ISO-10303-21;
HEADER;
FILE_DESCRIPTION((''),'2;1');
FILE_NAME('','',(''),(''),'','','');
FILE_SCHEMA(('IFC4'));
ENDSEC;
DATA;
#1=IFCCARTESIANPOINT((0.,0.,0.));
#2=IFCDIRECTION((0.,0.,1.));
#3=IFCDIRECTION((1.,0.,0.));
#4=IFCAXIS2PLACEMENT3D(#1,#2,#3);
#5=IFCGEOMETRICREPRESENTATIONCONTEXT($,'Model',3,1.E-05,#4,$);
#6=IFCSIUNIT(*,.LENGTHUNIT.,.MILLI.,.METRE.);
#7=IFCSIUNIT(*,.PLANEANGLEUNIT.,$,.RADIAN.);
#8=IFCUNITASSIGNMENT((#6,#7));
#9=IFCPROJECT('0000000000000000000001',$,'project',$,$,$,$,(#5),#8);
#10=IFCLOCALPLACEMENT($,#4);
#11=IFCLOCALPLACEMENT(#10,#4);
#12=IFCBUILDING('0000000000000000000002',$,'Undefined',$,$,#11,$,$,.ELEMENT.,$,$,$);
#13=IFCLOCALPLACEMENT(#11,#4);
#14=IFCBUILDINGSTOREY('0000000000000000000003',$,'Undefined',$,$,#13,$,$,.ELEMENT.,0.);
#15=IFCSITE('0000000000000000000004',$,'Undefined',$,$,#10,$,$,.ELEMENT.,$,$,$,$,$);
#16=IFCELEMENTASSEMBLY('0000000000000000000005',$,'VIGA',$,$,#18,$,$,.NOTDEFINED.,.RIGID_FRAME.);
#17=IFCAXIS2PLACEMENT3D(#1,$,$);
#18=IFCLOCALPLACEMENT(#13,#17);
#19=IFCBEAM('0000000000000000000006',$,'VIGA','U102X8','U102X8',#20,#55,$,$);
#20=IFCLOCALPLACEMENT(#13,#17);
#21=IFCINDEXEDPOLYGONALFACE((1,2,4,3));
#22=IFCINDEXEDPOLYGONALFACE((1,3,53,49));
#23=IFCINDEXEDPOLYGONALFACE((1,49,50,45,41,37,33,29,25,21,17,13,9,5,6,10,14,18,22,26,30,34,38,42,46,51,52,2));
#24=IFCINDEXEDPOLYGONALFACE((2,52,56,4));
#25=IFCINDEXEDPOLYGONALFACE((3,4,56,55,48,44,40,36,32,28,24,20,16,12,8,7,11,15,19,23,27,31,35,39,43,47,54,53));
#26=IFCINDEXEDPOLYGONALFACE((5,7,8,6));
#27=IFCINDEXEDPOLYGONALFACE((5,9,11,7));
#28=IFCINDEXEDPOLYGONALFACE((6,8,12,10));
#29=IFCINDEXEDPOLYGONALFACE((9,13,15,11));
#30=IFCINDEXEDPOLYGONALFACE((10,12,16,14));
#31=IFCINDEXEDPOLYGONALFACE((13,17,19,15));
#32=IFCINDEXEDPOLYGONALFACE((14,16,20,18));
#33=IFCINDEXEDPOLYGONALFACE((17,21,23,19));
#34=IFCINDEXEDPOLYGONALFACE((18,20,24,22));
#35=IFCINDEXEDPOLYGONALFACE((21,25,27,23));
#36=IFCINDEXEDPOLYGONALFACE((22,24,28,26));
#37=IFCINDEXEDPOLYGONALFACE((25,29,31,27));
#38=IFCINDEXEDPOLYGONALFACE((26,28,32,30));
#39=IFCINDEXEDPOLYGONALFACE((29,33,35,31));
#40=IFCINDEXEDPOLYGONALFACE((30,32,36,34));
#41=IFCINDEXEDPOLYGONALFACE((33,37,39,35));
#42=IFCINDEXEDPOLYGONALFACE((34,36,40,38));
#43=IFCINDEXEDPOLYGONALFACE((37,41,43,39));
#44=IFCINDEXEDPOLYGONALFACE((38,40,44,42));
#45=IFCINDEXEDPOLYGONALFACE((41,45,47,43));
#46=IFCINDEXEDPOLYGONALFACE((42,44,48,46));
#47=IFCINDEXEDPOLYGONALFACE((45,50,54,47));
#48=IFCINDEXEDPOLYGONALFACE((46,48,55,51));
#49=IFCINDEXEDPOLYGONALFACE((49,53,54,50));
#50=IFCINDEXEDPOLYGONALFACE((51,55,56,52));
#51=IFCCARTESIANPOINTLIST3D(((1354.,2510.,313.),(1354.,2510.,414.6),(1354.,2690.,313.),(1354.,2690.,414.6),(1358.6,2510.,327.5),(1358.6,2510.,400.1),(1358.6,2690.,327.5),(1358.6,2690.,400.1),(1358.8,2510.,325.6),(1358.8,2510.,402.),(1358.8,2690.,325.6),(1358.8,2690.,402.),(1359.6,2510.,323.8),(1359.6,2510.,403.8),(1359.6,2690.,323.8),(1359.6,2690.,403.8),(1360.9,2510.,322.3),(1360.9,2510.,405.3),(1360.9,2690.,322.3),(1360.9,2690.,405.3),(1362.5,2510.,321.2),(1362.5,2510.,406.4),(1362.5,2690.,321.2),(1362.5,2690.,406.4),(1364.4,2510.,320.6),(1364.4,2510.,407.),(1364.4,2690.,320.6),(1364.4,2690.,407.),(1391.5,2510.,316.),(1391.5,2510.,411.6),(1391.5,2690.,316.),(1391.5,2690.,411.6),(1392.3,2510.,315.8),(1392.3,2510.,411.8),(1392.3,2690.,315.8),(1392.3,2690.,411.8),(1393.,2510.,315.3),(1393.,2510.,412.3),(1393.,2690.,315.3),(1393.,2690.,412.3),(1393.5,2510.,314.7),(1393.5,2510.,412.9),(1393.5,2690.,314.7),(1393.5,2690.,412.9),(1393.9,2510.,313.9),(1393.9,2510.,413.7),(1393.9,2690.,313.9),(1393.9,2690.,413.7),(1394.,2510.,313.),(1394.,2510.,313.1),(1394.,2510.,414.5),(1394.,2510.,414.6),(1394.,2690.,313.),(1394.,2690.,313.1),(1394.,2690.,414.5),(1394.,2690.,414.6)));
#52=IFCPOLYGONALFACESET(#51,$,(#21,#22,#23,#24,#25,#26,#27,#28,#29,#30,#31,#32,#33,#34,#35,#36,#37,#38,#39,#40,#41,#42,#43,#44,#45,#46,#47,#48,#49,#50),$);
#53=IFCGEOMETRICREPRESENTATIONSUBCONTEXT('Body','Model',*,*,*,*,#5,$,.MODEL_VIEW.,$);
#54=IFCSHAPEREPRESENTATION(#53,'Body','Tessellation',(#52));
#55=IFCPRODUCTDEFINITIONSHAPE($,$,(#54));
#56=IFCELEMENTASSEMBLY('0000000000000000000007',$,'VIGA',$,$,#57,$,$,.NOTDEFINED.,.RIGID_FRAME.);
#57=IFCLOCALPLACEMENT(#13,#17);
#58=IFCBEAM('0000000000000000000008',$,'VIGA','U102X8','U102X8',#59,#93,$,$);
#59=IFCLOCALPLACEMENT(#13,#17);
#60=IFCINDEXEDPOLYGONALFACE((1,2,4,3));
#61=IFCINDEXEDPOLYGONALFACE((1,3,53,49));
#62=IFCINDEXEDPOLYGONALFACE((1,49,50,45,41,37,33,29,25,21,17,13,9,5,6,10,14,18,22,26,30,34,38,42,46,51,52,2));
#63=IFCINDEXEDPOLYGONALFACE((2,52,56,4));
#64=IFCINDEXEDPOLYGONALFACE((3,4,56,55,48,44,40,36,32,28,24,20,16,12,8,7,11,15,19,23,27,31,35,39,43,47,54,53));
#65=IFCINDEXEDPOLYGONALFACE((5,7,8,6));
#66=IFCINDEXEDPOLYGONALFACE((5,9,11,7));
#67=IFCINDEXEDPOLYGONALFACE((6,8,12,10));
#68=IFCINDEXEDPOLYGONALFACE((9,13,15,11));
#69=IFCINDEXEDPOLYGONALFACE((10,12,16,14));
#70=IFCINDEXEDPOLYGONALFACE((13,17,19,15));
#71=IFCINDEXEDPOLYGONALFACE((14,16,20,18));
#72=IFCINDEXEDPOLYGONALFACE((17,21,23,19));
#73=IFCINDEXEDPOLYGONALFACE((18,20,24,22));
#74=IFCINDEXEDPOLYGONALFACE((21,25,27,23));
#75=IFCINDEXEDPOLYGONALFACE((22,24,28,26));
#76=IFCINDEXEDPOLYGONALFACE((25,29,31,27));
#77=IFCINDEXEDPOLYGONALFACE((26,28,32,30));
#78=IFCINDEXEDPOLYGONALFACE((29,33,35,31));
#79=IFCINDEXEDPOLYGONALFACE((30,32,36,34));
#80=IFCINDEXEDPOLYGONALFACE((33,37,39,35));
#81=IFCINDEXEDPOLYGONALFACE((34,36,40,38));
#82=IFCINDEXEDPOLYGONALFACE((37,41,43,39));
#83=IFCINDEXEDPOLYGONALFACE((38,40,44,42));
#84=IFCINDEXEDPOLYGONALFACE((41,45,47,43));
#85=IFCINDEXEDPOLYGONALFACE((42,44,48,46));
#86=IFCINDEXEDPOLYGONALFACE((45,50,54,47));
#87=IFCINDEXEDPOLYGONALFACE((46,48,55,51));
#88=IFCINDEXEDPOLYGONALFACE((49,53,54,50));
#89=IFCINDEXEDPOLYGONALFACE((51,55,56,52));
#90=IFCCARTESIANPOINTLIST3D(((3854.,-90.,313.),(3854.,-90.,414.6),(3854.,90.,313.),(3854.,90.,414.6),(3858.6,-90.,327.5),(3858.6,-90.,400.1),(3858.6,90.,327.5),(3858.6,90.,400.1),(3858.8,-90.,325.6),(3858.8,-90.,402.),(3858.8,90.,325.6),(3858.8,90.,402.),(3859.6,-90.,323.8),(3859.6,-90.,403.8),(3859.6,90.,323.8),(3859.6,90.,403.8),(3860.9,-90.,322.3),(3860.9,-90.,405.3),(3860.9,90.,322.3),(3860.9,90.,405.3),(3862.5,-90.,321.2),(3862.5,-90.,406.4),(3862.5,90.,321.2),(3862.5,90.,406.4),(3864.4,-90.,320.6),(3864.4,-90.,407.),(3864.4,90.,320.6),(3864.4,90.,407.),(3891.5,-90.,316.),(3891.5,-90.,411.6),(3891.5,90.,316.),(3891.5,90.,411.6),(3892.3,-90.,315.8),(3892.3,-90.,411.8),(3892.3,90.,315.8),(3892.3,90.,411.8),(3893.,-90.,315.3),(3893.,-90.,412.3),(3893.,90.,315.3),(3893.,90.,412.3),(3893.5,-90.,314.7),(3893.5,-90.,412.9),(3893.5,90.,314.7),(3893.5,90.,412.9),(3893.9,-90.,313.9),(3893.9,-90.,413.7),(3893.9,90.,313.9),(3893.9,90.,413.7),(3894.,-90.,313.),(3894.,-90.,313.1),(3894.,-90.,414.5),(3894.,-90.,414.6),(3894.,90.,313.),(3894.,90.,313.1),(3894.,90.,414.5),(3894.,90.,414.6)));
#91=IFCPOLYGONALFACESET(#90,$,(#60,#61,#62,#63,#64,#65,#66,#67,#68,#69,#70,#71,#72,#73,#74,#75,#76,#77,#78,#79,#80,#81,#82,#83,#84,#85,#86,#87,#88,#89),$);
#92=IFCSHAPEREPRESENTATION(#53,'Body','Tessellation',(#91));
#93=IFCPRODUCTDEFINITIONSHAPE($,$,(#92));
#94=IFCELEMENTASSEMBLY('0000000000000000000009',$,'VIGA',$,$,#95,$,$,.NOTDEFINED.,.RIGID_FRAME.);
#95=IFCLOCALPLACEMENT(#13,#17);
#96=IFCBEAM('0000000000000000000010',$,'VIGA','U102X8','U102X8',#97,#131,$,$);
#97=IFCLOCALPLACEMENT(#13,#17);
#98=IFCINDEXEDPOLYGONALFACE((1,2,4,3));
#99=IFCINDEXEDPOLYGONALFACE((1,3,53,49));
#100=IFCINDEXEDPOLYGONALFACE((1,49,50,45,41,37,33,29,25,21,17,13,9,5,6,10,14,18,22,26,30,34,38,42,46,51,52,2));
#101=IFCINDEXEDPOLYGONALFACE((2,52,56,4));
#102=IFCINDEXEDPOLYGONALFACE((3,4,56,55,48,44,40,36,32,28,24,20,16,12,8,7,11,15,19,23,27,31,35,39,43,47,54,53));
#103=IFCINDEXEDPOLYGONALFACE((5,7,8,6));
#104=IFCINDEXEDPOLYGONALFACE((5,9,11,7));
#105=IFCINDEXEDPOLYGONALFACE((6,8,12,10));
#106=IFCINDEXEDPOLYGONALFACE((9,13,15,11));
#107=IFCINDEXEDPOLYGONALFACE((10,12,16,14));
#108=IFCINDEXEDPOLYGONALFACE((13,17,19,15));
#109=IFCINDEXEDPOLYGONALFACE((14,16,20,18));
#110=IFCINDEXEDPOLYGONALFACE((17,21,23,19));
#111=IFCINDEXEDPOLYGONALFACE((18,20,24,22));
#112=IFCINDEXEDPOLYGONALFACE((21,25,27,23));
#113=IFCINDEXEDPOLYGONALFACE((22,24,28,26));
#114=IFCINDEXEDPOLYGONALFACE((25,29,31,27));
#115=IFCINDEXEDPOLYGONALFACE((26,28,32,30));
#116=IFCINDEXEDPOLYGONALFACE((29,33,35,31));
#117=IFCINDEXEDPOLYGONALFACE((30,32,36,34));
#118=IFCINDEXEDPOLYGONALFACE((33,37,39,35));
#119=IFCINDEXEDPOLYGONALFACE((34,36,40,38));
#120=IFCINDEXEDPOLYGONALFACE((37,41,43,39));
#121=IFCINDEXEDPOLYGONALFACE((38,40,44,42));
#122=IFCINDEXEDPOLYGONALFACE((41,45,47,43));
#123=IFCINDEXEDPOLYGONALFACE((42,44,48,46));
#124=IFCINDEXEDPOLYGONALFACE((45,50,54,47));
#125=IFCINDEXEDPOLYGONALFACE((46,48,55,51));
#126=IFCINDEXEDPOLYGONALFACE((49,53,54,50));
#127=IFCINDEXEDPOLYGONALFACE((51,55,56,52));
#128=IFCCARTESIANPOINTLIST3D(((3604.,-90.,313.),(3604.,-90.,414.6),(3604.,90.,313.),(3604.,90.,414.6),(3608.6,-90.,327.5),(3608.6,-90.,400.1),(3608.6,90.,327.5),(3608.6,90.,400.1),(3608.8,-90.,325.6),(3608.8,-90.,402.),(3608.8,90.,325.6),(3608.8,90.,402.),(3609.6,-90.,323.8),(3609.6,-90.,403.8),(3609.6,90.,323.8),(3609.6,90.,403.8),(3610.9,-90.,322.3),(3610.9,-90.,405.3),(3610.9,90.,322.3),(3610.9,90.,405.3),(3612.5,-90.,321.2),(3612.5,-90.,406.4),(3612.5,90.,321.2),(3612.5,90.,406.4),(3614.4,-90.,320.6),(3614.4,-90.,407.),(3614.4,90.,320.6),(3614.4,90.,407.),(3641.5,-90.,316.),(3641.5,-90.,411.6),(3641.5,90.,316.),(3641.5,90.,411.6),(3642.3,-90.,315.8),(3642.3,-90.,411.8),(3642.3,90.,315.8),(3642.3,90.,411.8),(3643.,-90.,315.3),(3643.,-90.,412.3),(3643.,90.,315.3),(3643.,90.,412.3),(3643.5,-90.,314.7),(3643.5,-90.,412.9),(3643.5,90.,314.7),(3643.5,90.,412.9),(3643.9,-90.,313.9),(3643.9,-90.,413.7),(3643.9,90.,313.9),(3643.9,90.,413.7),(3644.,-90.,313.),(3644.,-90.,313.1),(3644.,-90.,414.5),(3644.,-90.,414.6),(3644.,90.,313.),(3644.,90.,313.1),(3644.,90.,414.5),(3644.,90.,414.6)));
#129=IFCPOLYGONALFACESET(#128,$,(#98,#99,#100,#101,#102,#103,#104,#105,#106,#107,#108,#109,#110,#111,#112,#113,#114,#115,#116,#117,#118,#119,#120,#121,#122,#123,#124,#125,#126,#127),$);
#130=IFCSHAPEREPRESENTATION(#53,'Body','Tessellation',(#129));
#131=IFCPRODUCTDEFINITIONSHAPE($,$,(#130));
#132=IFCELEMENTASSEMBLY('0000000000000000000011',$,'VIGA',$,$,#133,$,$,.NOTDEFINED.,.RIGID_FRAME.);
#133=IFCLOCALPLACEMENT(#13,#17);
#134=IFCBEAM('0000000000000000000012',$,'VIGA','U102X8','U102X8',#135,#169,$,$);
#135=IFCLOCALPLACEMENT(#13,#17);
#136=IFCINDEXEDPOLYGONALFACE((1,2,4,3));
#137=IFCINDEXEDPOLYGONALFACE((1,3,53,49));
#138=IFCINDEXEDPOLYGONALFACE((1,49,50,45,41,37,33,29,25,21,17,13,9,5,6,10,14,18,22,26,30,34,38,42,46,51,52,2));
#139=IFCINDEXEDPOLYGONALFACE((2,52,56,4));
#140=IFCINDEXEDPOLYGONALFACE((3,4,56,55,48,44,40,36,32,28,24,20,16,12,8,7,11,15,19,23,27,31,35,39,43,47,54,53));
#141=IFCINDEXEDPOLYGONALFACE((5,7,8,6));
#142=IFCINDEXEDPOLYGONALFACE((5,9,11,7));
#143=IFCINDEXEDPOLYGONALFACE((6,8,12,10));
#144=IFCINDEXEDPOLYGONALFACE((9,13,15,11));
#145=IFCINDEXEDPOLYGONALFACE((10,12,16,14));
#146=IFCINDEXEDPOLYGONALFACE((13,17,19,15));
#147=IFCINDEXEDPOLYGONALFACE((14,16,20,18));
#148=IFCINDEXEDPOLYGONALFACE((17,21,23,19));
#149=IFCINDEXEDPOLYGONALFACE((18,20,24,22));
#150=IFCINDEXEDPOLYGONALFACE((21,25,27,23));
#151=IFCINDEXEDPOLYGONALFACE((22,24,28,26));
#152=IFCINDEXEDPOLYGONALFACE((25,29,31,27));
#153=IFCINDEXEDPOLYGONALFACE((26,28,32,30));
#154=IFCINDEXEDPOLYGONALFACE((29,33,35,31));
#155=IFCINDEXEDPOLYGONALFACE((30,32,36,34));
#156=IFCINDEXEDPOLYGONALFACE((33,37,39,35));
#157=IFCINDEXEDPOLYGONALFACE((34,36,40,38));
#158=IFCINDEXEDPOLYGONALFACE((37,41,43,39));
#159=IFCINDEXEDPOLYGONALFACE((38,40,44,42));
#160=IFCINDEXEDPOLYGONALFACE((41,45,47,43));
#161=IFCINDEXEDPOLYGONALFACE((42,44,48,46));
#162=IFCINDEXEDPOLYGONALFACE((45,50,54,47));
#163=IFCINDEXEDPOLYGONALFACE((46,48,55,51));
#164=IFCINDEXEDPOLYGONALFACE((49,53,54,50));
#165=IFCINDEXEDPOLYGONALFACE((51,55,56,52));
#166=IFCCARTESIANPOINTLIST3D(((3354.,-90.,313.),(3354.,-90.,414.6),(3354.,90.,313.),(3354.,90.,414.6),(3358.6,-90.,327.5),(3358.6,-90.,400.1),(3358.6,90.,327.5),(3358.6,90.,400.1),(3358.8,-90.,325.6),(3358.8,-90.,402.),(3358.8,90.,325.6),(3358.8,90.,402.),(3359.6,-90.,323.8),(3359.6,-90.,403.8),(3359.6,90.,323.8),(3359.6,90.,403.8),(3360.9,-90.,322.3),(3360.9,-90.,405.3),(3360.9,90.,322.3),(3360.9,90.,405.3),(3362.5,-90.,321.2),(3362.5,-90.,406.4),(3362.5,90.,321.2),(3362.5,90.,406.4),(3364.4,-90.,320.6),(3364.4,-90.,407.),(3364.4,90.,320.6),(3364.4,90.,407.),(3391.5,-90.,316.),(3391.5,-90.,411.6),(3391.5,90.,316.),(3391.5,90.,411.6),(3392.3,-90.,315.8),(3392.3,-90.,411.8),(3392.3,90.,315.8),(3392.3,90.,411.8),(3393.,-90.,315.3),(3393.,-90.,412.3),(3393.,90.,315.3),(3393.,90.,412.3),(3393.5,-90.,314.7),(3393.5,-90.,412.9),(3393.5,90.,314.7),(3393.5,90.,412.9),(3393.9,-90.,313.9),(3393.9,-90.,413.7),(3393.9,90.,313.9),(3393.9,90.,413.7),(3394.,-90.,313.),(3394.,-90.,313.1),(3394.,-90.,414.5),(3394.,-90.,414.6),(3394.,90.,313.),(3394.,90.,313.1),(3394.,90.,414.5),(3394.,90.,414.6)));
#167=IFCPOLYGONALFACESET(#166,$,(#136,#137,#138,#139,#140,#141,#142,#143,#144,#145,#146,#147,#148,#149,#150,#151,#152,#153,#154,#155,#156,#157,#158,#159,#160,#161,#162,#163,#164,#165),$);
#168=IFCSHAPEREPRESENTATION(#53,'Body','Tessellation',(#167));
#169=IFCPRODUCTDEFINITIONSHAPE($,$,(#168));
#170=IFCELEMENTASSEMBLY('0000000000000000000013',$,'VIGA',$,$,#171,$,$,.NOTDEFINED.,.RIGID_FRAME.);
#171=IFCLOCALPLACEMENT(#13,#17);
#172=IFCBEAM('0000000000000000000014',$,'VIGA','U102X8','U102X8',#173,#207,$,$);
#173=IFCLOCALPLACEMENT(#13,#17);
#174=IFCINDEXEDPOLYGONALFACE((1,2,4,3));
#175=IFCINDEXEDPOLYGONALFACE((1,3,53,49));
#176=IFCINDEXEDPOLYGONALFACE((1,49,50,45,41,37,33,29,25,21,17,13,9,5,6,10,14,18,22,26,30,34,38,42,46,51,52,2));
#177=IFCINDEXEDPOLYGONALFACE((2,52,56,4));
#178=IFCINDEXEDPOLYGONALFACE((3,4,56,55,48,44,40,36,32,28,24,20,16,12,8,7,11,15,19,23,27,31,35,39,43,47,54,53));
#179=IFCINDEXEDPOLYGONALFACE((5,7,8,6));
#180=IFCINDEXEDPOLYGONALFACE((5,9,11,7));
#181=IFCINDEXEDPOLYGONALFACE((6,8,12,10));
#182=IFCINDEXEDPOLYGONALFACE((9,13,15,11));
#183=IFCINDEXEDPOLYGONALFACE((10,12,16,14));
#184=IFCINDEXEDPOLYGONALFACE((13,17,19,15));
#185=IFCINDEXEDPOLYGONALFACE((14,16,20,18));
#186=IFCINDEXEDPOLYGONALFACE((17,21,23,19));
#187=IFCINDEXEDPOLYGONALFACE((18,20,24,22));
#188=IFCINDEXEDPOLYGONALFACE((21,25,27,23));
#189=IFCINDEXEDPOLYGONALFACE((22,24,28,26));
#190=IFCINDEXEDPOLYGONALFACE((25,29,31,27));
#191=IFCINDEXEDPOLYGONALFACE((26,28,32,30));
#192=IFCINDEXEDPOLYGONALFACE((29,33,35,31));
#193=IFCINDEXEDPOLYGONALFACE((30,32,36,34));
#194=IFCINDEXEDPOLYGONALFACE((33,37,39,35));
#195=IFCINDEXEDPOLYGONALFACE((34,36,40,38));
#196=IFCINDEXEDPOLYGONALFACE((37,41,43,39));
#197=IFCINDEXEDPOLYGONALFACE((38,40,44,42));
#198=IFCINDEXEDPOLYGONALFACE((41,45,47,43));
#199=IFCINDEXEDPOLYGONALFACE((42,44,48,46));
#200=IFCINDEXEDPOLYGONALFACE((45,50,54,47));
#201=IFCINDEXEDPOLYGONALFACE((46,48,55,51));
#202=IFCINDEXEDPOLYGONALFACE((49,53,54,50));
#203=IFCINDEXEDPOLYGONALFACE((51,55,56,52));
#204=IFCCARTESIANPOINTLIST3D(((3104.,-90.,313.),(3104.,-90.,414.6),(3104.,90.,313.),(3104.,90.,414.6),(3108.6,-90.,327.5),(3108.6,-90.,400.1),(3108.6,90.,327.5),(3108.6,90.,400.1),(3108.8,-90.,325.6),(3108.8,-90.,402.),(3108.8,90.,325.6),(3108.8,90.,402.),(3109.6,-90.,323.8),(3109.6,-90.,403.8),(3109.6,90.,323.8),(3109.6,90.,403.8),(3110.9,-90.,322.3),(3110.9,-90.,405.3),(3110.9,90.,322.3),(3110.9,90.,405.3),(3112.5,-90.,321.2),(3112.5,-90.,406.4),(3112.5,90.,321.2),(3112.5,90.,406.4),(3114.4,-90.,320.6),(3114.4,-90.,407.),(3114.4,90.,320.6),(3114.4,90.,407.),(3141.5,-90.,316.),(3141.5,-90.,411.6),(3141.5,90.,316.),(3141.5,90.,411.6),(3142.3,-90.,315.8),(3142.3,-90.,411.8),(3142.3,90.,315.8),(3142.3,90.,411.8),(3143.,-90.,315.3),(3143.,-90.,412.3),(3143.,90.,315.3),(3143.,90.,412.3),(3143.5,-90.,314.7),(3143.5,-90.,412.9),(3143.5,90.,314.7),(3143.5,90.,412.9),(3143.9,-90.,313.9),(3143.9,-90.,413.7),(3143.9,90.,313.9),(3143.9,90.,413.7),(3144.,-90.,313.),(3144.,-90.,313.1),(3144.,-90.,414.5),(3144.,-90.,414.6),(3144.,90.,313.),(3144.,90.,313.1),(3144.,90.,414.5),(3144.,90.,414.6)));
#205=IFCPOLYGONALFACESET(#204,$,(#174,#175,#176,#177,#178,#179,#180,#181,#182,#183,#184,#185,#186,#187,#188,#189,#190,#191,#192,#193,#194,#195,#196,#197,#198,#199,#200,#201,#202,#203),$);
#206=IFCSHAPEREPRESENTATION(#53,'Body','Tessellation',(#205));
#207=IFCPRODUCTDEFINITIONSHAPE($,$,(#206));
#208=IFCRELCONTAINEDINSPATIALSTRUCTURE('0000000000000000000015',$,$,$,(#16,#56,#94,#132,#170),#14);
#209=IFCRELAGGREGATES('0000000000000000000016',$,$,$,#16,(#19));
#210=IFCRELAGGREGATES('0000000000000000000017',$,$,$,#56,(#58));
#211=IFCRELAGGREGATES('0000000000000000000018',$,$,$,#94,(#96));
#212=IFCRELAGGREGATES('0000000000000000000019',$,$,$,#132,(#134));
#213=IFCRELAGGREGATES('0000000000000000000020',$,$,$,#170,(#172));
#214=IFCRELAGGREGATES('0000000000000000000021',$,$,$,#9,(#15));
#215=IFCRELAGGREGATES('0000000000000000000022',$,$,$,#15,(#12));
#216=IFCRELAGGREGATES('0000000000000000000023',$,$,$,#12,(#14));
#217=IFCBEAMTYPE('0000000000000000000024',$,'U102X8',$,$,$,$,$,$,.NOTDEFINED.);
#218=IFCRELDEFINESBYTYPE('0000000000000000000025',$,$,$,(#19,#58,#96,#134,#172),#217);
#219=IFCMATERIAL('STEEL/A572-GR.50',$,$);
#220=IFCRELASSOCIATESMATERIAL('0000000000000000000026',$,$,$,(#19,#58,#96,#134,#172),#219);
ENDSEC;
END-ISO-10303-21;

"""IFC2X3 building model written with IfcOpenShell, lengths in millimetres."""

from ifc_helpers import new_model, si_unit, frame, origin_with_axes, origin_2d_with_axis, place, context, subcontext, project, spatial, u_section, extrude, material, type_object, element, aggregate, save


model = new_model("IFC2X3")

# Units and contexts
model_context = context("Model", 3, precision=1e-05, world=origin_with_axes())
body_context = subcontext(model_context, "Body", "Model", "MODEL_VIEW")
ifc_project = project(units=[si_unit("LENGTHUNIT", "METRE", prefix="MILLI"), si_unit("PLANEANGLEUNIT", "RADIAN")], contexts=[model_context])

# Site, building, storey
site_placement = place(None, origin_with_axes())
site = spatial("IfcSite", under=ifc_project, at=site_placement, Name="Undefined", CompositionType="ELEMENT")
building_placement = place(site_placement, origin_with_axes())
building = spatial("IfcBuilding", under=site, at=building_placement, Name="Undefined", CompositionType="ELEMENT")
storey_placement = place(building_placement, origin_with_axes())
storey = spatial("IfcBuildingStorey", under=building, at=storey_placement, Name="Undefined", CompositionType="ELEMENT", Elevation=0.0)

# Element assemblies, beams
ifc_material = material(Name="STEEL/A572-GR.50")
beam_type = type_object("IfcBeamType", Name="U102X8", PredefinedType="NOTDEFINED")
assembly_1_placement = place(storey_placement, origin_with_axes())
assembly_1 = element("IfcElementAssembly", 1, at=assembly_1_placement, inside=storey, Name="VIGA", AssemblyPlace="NOTDEFINED", PredefinedType="RIGID_FRAME")
beam_1_placement = place(assembly_1_placement, frame((1374.0, 2510.0, 363.8), z_axis=(0.0, 0.0, 1.0), x_axis=(0.0, 1.0, 0.0)))
beam_1 = element("IfcBeam", 2, at=beam_1_placement, type_object=beam_type, material=ifc_material, Name="VIGA", Description="U102X8", ObjectType="U102X8", context=body_context, shape_type="SweptSolid", body=[
    extrude(u_section(Depth=101.6, FlangeWidth=40.0, WebThickness=4.6, FlangeThickness=6.0, FilletRadius=7.0, EdgeRadius=3.0, FlangeSlope=0.16839, at=origin_2d_with_axis()), frame((180.0, 0.0, 0.0), z_axis=(-1.0, 0.0, 0.0), x_axis=(0.0, -1.0, 0.0)), (0.0, 0.0, 1.0), 180.0),
])
aggregate(assembly_1, [beam_1])
assembly_2_placement = place(storey_placement, origin_with_axes())
assembly_2 = element("IfcElementAssembly", 3, at=assembly_2_placement, inside=storey, Name="VIGA", AssemblyPlace="NOTDEFINED", PredefinedType="RIGID_FRAME")
beam_2_placement = place(assembly_2_placement, frame((3874.0, -90.0, 363.8), z_axis=(0.0, 0.0, 1.0), x_axis=(0.0, 1.0, 0.0)))
beam_2 = element("IfcBeam", 4, at=beam_2_placement, type_object=beam_type, material=ifc_material, Name="VIGA", Description="U102X8", ObjectType="U102X8", context=body_context, shape_type="SweptSolid", body=[
    extrude(u_section(Depth=101.6, FlangeWidth=40.0, WebThickness=4.6, FlangeThickness=6.0, FilletRadius=7.0, EdgeRadius=3.0, FlangeSlope=0.16839, at=origin_2d_with_axis()), frame((180.0, 0.0, 0.0), z_axis=(-1.0, 0.0, 0.0), x_axis=(0.0, -1.0, 0.0)), (0.0, 0.0, 1.0), 180.0),
])
aggregate(assembly_2, [beam_2])
assembly_3_placement = place(storey_placement, origin_with_axes())
assembly_3 = element("IfcElementAssembly", 5, at=assembly_3_placement, inside=storey, Name="VIGA", AssemblyPlace="NOTDEFINED", PredefinedType="RIGID_FRAME")
beam_3_placement = place(assembly_3_placement, frame((3624.0, -90.0, 363.8), z_axis=(0.0, 0.0, 1.0), x_axis=(0.0, 1.0, 0.0)))
beam_3 = element("IfcBeam", 6, at=beam_3_placement, type_object=beam_type, material=ifc_material, Name="VIGA", Description="U102X8", ObjectType="U102X8", context=body_context, shape_type="SweptSolid", body=[
    extrude(u_section(Depth=101.6, FlangeWidth=40.0, WebThickness=4.6, FlangeThickness=6.0, FilletRadius=7.0, EdgeRadius=3.0, FlangeSlope=0.16839, at=origin_2d_with_axis()), frame((180.0, 0.0, 0.0), z_axis=(-1.0, 0.0, 0.0), x_axis=(0.0, -1.0, 0.0)), (0.0, 0.0, 1.0), 180.0),
])
aggregate(assembly_3, [beam_3])
assembly_4_placement = place(storey_placement, origin_with_axes())
assembly_4 = element("IfcElementAssembly", 7, at=assembly_4_placement, inside=storey, Name="VIGA", AssemblyPlace="NOTDEFINED", PredefinedType="RIGID_FRAME")
beam_4_placement = place(assembly_4_placement, frame((3374.0, -90.0, 363.8), z_axis=(0.0, 0.0, 1.0), x_axis=(0.0, 1.0, 0.0)))
beam_4 = element("IfcBeam", 8, at=beam_4_placement, type_object=beam_type, material=ifc_material, Name="VIGA", Description="U102X8", ObjectType="U102X8", context=body_context, shape_type="SweptSolid", body=[
    extrude(u_section(Depth=101.6, FlangeWidth=40.0, WebThickness=4.6, FlangeThickness=6.0, FilletRadius=7.0, EdgeRadius=3.0, FlangeSlope=0.16839, at=origin_2d_with_axis()), frame((180.0, 0.0, 0.0), z_axis=(-1.0, 0.0, 0.0), x_axis=(0.0, -1.0, 0.0)), (0.0, 0.0, 1.0), 180.0),
])
aggregate(assembly_4, [beam_4])
assembly_5_placement = place(storey_placement, origin_with_axes())
assembly_5 = element("IfcElementAssembly", 9, at=assembly_5_placement, inside=storey, Name="VIGA", AssemblyPlace="NOTDEFINED", PredefinedType="RIGID_FRAME")
beam_5_placement = place(assembly_5_placement, frame((3124.0, -90.0, 363.8), z_axis=(0.0, 0.0, 1.0), x_axis=(0.0, 1.0, 0.0)))
beam_5 = element("IfcBeam", 10, at=beam_5_placement, type_object=beam_type, material=ifc_material, Name="VIGA", Description="U102X8", ObjectType="U102X8", context=body_context, shape_type="SweptSolid", body=[
    extrude(u_section(Depth=101.6, FlangeWidth=40.0, WebThickness=4.6, FlangeThickness=6.0, FilletRadius=7.0, EdgeRadius=3.0, FlangeSlope=0.16839, at=origin_2d_with_axis()), frame((180.0, 0.0, 0.0), z_axis=(-1.0, 0.0, 0.0), x_axis=(0.0, -1.0, 0.0)), (0.0, 0.0, 1.0), 180.0),
])
aggregate(assembly_5, [beam_5])

save(model, "model.ifc")
